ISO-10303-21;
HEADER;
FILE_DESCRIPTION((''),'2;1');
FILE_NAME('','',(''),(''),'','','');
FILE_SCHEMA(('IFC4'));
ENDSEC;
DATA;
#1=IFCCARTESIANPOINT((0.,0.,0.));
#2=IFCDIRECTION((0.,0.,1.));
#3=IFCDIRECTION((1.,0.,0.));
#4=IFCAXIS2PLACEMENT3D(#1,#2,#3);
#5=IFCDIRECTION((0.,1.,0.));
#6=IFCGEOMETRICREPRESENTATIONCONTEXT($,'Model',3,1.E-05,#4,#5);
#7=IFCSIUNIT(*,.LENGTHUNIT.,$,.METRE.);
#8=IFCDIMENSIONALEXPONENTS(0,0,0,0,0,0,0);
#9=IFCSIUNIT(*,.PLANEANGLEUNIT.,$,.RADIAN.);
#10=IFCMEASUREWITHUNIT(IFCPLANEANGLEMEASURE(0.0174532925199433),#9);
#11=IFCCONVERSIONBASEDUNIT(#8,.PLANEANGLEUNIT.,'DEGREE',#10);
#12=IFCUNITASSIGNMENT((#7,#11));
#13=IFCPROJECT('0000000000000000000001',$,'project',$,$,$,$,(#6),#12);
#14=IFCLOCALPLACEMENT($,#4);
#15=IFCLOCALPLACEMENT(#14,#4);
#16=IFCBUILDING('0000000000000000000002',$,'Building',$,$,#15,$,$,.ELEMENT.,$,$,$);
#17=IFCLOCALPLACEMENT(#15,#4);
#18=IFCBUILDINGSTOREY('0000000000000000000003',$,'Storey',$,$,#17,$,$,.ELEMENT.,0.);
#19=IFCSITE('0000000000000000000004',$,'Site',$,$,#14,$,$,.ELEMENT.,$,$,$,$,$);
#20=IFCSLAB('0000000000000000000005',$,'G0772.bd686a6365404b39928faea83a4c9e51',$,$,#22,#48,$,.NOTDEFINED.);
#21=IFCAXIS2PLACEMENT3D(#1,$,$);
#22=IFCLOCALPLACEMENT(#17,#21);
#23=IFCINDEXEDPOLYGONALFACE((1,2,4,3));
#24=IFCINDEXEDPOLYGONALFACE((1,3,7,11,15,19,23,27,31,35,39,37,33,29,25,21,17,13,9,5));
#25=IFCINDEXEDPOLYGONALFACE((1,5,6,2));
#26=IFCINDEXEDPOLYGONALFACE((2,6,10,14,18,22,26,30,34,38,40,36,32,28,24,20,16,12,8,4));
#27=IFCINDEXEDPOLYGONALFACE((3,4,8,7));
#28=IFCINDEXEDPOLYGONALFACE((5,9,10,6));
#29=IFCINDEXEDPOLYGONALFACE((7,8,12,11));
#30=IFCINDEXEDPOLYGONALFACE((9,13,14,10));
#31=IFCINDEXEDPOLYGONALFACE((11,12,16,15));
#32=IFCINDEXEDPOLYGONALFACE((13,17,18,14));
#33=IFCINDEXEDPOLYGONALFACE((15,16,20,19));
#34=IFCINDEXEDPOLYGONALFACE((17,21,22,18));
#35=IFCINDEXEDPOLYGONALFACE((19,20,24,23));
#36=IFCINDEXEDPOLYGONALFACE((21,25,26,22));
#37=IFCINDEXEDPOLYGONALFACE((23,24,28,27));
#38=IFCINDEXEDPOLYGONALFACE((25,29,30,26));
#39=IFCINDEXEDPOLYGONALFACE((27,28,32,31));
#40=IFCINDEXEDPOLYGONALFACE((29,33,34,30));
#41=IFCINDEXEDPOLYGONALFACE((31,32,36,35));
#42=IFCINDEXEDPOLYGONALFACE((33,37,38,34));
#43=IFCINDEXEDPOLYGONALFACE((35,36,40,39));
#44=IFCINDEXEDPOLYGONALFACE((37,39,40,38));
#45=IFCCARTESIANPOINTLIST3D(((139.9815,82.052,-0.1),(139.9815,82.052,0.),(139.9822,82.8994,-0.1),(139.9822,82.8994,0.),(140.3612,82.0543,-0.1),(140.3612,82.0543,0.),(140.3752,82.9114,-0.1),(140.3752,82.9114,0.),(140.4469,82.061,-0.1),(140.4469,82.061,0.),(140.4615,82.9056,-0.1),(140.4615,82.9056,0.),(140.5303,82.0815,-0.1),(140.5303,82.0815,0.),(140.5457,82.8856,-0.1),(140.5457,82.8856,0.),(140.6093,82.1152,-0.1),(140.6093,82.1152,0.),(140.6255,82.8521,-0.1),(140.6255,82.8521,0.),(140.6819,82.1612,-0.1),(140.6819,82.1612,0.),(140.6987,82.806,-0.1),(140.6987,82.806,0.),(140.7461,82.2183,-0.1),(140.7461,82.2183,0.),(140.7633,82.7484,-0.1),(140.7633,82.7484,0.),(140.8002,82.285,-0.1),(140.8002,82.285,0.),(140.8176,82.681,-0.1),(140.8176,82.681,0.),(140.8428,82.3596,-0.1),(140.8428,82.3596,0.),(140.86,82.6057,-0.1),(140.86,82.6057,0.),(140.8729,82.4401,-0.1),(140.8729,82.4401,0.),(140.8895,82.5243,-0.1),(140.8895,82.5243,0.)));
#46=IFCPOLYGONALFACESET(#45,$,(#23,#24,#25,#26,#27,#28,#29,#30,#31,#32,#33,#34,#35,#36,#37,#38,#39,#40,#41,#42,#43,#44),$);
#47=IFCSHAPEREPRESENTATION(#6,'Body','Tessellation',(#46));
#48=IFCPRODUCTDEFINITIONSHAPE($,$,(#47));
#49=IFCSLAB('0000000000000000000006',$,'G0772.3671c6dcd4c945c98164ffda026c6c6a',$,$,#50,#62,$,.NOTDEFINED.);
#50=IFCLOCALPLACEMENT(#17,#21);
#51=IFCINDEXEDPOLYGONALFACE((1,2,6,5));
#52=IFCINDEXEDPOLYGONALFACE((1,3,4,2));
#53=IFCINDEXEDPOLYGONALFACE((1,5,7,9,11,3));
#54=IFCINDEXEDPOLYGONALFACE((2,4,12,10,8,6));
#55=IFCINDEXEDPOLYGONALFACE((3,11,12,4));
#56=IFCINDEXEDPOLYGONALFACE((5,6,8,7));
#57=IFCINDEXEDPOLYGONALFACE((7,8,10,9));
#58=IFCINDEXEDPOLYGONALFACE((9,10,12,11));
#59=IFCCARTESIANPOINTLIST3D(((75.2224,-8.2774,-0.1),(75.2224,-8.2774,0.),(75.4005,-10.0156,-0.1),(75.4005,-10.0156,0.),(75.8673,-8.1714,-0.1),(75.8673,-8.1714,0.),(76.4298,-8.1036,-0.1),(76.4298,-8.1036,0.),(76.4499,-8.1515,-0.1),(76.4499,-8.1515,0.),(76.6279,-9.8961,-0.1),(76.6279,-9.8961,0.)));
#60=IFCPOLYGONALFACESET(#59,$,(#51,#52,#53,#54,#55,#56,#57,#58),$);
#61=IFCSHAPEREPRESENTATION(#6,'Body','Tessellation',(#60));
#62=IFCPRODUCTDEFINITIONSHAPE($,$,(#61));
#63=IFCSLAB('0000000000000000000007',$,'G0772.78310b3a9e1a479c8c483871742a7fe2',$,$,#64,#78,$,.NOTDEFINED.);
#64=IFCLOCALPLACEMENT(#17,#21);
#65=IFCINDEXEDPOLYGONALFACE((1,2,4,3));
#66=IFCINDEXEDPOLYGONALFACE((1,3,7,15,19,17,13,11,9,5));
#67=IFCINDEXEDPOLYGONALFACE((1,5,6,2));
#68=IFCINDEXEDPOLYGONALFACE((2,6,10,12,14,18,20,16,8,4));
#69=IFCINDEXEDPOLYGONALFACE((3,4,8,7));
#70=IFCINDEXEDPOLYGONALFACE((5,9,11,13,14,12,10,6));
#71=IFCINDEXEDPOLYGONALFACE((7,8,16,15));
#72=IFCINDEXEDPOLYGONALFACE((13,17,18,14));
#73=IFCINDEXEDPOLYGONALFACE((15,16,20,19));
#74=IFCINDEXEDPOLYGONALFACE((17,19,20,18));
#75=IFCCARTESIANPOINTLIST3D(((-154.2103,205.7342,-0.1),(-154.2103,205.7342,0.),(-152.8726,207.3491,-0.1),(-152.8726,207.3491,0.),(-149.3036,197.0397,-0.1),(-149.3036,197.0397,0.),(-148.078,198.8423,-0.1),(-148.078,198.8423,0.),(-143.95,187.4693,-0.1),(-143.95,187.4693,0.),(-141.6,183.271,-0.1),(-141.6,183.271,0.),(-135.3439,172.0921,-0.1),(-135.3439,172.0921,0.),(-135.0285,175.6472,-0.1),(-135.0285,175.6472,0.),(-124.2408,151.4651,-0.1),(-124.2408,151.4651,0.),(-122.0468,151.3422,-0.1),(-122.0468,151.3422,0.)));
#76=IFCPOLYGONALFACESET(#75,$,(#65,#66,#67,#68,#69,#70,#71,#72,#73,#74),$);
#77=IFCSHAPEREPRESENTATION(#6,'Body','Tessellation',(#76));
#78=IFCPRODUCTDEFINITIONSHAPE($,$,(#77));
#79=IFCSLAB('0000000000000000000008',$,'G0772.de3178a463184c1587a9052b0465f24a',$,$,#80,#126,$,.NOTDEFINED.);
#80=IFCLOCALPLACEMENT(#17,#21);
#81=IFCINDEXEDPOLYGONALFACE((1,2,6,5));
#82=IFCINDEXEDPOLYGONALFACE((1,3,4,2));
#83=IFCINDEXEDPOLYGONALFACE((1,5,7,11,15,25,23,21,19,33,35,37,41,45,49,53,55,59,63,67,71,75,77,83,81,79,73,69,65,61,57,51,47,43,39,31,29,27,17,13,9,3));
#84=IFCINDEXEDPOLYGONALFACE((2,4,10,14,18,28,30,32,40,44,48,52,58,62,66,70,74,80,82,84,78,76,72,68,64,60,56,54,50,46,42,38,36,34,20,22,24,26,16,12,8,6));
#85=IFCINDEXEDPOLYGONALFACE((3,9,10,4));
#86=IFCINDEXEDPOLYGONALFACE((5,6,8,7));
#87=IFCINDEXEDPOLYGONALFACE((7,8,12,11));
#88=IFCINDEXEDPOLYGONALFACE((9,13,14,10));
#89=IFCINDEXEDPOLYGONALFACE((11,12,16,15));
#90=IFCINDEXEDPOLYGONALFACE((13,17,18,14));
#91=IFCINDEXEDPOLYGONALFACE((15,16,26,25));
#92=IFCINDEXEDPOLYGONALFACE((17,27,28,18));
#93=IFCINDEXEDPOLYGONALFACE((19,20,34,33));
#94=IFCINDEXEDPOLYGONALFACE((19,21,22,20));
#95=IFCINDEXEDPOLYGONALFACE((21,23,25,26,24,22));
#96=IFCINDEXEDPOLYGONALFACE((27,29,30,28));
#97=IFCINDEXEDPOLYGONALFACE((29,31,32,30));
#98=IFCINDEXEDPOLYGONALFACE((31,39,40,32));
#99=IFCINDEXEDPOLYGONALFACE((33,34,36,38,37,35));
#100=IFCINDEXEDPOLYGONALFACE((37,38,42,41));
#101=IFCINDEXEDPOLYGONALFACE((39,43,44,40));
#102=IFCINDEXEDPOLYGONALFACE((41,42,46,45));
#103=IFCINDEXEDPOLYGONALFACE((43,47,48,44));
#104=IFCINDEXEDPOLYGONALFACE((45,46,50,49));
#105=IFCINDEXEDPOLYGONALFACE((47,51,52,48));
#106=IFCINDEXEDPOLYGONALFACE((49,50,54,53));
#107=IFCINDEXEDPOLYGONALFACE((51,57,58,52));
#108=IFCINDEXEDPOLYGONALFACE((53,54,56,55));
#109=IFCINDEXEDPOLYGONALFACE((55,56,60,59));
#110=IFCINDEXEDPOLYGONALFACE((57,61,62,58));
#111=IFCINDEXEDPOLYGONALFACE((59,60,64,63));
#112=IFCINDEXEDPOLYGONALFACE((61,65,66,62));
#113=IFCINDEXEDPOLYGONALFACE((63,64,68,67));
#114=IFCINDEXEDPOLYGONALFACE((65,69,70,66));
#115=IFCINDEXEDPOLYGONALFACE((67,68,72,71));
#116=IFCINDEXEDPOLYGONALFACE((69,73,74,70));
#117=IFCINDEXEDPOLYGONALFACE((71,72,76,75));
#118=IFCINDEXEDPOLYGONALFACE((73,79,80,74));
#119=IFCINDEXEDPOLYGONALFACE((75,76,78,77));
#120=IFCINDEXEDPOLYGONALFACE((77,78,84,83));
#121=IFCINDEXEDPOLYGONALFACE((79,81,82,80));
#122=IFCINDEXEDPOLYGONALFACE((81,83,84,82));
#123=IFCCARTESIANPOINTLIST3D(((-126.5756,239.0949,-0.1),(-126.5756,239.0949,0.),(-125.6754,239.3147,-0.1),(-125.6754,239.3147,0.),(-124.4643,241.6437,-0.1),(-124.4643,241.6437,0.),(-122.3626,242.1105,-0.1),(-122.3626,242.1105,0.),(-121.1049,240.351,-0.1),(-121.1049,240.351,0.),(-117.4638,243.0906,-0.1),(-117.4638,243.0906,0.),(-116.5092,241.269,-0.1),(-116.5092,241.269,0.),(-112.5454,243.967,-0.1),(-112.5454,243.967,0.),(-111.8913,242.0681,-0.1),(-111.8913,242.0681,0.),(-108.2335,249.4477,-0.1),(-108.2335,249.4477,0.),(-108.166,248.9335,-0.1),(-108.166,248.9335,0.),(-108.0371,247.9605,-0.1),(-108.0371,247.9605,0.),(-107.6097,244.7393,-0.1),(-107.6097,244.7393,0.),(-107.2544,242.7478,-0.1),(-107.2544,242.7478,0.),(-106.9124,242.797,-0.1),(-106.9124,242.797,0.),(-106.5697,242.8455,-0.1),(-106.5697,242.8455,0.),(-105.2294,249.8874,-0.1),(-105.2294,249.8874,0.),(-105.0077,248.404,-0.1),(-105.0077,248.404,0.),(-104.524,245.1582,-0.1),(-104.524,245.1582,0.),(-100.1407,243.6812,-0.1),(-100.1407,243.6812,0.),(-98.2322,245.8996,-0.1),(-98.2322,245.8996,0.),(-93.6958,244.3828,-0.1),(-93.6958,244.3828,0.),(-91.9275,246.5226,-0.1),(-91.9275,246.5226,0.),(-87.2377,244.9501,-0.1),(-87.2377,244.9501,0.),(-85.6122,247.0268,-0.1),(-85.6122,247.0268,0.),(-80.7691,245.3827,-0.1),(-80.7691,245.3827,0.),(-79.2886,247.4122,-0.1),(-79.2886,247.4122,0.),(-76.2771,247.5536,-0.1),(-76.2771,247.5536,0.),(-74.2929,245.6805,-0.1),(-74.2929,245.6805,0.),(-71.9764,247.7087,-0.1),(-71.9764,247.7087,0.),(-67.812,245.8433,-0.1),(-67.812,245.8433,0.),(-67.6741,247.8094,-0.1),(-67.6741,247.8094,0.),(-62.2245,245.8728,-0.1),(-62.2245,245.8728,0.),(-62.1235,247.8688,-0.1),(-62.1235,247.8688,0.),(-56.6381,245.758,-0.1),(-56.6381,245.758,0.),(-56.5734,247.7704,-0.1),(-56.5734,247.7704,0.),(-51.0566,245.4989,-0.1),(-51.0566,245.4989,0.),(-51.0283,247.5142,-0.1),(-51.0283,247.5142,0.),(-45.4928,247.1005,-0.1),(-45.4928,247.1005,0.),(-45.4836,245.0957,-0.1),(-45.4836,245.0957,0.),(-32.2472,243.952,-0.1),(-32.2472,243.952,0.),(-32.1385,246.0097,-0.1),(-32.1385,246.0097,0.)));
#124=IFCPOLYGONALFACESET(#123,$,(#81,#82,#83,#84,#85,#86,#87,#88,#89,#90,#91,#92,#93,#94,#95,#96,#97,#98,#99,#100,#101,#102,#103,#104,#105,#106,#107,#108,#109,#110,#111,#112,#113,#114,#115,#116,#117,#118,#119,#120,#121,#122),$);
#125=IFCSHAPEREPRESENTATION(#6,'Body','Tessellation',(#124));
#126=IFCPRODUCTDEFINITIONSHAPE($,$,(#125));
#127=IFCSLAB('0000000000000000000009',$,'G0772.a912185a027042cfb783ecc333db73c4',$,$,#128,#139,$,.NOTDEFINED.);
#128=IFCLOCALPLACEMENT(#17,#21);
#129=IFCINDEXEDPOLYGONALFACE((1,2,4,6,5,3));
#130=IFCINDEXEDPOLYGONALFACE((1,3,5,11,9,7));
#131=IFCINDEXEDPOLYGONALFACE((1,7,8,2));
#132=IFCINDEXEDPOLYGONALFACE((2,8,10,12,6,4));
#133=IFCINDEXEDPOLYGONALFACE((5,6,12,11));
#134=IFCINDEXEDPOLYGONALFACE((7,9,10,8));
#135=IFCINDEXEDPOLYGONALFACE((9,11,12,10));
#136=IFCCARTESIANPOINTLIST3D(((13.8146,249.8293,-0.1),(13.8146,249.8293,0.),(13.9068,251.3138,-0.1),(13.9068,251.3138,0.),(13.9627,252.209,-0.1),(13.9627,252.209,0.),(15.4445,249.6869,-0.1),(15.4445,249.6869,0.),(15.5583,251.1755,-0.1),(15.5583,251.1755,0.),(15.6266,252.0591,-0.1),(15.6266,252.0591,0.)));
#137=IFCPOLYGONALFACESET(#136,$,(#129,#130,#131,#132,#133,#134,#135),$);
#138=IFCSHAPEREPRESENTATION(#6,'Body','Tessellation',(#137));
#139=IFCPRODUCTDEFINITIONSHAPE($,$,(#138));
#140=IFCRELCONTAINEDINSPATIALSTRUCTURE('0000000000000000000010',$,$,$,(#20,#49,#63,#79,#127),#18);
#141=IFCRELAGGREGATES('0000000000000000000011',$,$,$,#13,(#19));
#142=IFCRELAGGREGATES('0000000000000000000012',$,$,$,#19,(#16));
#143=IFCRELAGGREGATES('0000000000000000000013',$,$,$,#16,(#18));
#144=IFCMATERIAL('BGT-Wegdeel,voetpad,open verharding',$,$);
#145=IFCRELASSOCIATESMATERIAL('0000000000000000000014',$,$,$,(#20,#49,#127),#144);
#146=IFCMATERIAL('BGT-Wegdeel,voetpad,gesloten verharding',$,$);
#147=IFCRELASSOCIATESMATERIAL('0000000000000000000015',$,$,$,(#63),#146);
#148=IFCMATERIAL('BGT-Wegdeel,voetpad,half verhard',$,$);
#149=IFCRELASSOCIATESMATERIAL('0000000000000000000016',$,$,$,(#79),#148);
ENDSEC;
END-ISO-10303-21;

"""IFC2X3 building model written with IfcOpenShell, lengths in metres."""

from ifc_helpers import new_model, entity, si_unit, converted_unit, direction, frame, origin_with_axes, place, context, project, spatial, polyline, outline, extrude, material, element, save


model = new_model("IFC2X3")

# Units and contexts
model_context = context("Model", 3, precision=1e-05, world=origin_with_axes(), true_north=direction((0.0, 1.0, 0.0)))
ifc_project = project(units=[si_unit("LENGTHUNIT", "METRE"), converted_unit("PLANEANGLEUNIT", "DEGREE", entity("IfcPlaneAngleMeasure", 0.0174532925199433), si_unit("PLANEANGLEUNIT", "RADIAN"), dimensions=[0, 0, 0, 0, 0, 0, 0])], contexts=[model_context])

# Site, building, storey
site_placement = place(None, origin_with_axes())
site = spatial("IfcSite", under=ifc_project, at=site_placement, Name="Site", CompositionType="ELEMENT")
building_placement = place(site_placement, origin_with_axes())
building = spatial("IfcBuilding", under=site, at=building_placement, Name="Building", CompositionType="ELEMENT")
storey_placement = place(building_placement, origin_with_axes())
storey = spatial("IfcBuildingStorey", under=building, at=storey_placement, Name="Storey", CompositionType="ELEMENT", Elevation=0.0)

# Slabs
ifc_material_1 = material(Name="BGT-Wegdeel,voetpad,half verhard")
ifc_material_2 = material(Name="BGT-Wegdeel,voetpad,open verharding")
slab_1_placement = place(storey_placement, frame((0.0, 0.0, -0.1), z_axis=(0.0, 0.0, 1.0), x_axis=(1.0, 0.0, 0.0)))
element("IfcSlab", 1, at=slab_1_placement, inside=storey, material=ifc_material_2, Name="G0772.bd686a6365404b39928faea83a4c9e51", PredefinedType="NOTDEFINED", context=model_context, shape_type="SweptSolid", body=[
    extrude(outline(polyline([(140.3752, 82.9114), (140.4615, 82.9056), (140.5457, 82.8856), (140.6255, 82.8521), (140.6987, 82.806), (140.7633, 82.7484), (140.8176, 82.681), (140.86, 82.6057), (140.8895, 82.5243), (140.8729, 82.4401), (140.8428, 82.3596), (140.8002, 82.285), (140.7461, 82.2183), (140.6819, 82.1612), (140.6093, 82.1152), (140.5303, 82.0815), (140.4469, 82.061), (140.3612, 82.0543), (139.9815, 82.052), (139.9822, 82.8994), (140.3752, 82.9114)])), origin_with_axes(), (0.0, 0.0, 1.0), 0.1),
])
slab_2_placement = place(storey_placement, frame((0.0, 0.0, -0.1), z_axis=(0.0, 0.0, 1.0), x_axis=(1.0, 0.0, 0.0)))
element("IfcSlab", 2, at=slab_2_placement, inside=storey, material=ifc_material_2, Name="G0772.3671c6dcd4c945c98164ffda026c6c6a", PredefinedType="NOTDEFINED", context=model_context, shape_type="SweptSolid", body=[
    extrude(outline(polyline([(75.2224, -8.2774), (75.8673, -8.1714), (76.4298, -8.1036), (76.4499, -8.1515), (76.6279, -9.8961), (75.4005, -10.0156), (75.2224, -8.2774)])), origin_with_axes(), (0.0, 0.0, 1.0), 0.1),
])
ifc_material_3 = material(Name="BGT-Wegdeel,voetpad,gesloten verharding")
slab_3_placement = place(storey_placement, frame((0.0, 0.0, -0.1), z_axis=(0.0, 0.0, 1.0), x_axis=(1.0, 0.0, 0.0)))
element("IfcSlab", 3, at=slab_3_placement, inside=storey, material=ifc_material_3, Name="G0772.78310b3a9e1a479c8c483871742a7fe2", PredefinedType="NOTDEFINED", context=model_context, shape_type="SweptSolid", body=[
    extrude(outline(polyline([(-148.078, 198.8423), (-135.0285, 175.6472), (-122.0468, 151.3422), (-124.2408, 151.4651), (-135.3439, 172.0921), (-141.6, 183.271), (-143.95, 187.4693), (-149.3036, 197.0397), (-154.2103, 205.7342), (-152.8726, 207.3491), (-148.078, 198.8423)])), origin_with_axes(), (0.0, 0.0, 1.0), 0.1),
])
slab_4_placement = place(storey_placement, frame((0.0, 0.0, -0.1), z_axis=(0.0, 0.0, 1.0), x_axis=(1.0, 0.0, 0.0)))
element("IfcSlab", 4, at=slab_4_placement, inside=storey, material=ifc_material_1, Name="G0772.de3178a463184c1587a9052b0465f24a", PredefinedType="NOTDEFINED", context=model_context, shape_type="SweptSolid", body=[
    extrude(outline(polyline([(-122.3626, 242.1105), (-117.4638, 243.0906), (-112.5454, 243.967), (-107.6097, 244.7393), (-108.0371, 247.9605), (-108.166, 248.9335), (-108.2335, 249.4477), (-105.2294, 249.8874), (-105.0077, 248.404), (-104.524, 245.1582), (-98.2322, 245.8996), (-91.9275, 246.5226), (-85.6122, 247.0268), (-79.2886, 247.4122), (-76.2771, 247.5536), (-71.9764, 247.7087), (-67.6741, 247.8094), (-62.1235, 247.8688), (-56.5734, 247.7704), (-51.0283, 247.5142), (-45.4928, 247.1005), (-32.1385, 246.0097), (-32.2472, 243.952), (-45.4836, 245.0957), (-51.0566, 245.4989), (-56.6381, 245.758), (-62.2245, 245.8728), (-67.812, 245.8433), (-74.2929, 245.6805), (-80.7691, 245.3827), (-87.2377, 244.9501), (-93.6958, 244.3828), (-100.1407, 243.6812), (-106.5697, 242.8455), (-106.9124, 242.797), (-107.2544, 242.7478), (-111.8913, 242.0681), (-116.5092, 241.269), (-121.1049, 240.351), (-125.6754, 239.3147), (-126.5756, 239.0949), (-124.4643, 241.6437), (-122.3626, 242.1105)])), origin_with_axes(), (0.0, 0.0, 1.0), 0.1),
])
slab_5_placement = place(storey_placement, frame((0.0, 0.0, -0.1), z_axis=(0.0, 0.0, 1.0), x_axis=(1.0, 0.0, 0.0)))
element("IfcSlab", 5, at=slab_5_placement, inside=storey, material=ifc_material_2, Name="G0772.a912185a027042cfb783ecc333db73c4", PredefinedType="NOTDEFINED", context=model_context, shape_type="SweptSolid", body=[
    extrude(outline(polyline([(15.6266, 252.0591), (15.5583, 251.1755), (15.4445, 249.6869), (13.8146, 249.8293), (13.9068, 251.3138), (13.9627, 252.209), (15.6266, 252.0591)])), origin_with_axes(), (0.0, 0.0, 1.0), 0.1),
])

save(model, "model.ifc")
